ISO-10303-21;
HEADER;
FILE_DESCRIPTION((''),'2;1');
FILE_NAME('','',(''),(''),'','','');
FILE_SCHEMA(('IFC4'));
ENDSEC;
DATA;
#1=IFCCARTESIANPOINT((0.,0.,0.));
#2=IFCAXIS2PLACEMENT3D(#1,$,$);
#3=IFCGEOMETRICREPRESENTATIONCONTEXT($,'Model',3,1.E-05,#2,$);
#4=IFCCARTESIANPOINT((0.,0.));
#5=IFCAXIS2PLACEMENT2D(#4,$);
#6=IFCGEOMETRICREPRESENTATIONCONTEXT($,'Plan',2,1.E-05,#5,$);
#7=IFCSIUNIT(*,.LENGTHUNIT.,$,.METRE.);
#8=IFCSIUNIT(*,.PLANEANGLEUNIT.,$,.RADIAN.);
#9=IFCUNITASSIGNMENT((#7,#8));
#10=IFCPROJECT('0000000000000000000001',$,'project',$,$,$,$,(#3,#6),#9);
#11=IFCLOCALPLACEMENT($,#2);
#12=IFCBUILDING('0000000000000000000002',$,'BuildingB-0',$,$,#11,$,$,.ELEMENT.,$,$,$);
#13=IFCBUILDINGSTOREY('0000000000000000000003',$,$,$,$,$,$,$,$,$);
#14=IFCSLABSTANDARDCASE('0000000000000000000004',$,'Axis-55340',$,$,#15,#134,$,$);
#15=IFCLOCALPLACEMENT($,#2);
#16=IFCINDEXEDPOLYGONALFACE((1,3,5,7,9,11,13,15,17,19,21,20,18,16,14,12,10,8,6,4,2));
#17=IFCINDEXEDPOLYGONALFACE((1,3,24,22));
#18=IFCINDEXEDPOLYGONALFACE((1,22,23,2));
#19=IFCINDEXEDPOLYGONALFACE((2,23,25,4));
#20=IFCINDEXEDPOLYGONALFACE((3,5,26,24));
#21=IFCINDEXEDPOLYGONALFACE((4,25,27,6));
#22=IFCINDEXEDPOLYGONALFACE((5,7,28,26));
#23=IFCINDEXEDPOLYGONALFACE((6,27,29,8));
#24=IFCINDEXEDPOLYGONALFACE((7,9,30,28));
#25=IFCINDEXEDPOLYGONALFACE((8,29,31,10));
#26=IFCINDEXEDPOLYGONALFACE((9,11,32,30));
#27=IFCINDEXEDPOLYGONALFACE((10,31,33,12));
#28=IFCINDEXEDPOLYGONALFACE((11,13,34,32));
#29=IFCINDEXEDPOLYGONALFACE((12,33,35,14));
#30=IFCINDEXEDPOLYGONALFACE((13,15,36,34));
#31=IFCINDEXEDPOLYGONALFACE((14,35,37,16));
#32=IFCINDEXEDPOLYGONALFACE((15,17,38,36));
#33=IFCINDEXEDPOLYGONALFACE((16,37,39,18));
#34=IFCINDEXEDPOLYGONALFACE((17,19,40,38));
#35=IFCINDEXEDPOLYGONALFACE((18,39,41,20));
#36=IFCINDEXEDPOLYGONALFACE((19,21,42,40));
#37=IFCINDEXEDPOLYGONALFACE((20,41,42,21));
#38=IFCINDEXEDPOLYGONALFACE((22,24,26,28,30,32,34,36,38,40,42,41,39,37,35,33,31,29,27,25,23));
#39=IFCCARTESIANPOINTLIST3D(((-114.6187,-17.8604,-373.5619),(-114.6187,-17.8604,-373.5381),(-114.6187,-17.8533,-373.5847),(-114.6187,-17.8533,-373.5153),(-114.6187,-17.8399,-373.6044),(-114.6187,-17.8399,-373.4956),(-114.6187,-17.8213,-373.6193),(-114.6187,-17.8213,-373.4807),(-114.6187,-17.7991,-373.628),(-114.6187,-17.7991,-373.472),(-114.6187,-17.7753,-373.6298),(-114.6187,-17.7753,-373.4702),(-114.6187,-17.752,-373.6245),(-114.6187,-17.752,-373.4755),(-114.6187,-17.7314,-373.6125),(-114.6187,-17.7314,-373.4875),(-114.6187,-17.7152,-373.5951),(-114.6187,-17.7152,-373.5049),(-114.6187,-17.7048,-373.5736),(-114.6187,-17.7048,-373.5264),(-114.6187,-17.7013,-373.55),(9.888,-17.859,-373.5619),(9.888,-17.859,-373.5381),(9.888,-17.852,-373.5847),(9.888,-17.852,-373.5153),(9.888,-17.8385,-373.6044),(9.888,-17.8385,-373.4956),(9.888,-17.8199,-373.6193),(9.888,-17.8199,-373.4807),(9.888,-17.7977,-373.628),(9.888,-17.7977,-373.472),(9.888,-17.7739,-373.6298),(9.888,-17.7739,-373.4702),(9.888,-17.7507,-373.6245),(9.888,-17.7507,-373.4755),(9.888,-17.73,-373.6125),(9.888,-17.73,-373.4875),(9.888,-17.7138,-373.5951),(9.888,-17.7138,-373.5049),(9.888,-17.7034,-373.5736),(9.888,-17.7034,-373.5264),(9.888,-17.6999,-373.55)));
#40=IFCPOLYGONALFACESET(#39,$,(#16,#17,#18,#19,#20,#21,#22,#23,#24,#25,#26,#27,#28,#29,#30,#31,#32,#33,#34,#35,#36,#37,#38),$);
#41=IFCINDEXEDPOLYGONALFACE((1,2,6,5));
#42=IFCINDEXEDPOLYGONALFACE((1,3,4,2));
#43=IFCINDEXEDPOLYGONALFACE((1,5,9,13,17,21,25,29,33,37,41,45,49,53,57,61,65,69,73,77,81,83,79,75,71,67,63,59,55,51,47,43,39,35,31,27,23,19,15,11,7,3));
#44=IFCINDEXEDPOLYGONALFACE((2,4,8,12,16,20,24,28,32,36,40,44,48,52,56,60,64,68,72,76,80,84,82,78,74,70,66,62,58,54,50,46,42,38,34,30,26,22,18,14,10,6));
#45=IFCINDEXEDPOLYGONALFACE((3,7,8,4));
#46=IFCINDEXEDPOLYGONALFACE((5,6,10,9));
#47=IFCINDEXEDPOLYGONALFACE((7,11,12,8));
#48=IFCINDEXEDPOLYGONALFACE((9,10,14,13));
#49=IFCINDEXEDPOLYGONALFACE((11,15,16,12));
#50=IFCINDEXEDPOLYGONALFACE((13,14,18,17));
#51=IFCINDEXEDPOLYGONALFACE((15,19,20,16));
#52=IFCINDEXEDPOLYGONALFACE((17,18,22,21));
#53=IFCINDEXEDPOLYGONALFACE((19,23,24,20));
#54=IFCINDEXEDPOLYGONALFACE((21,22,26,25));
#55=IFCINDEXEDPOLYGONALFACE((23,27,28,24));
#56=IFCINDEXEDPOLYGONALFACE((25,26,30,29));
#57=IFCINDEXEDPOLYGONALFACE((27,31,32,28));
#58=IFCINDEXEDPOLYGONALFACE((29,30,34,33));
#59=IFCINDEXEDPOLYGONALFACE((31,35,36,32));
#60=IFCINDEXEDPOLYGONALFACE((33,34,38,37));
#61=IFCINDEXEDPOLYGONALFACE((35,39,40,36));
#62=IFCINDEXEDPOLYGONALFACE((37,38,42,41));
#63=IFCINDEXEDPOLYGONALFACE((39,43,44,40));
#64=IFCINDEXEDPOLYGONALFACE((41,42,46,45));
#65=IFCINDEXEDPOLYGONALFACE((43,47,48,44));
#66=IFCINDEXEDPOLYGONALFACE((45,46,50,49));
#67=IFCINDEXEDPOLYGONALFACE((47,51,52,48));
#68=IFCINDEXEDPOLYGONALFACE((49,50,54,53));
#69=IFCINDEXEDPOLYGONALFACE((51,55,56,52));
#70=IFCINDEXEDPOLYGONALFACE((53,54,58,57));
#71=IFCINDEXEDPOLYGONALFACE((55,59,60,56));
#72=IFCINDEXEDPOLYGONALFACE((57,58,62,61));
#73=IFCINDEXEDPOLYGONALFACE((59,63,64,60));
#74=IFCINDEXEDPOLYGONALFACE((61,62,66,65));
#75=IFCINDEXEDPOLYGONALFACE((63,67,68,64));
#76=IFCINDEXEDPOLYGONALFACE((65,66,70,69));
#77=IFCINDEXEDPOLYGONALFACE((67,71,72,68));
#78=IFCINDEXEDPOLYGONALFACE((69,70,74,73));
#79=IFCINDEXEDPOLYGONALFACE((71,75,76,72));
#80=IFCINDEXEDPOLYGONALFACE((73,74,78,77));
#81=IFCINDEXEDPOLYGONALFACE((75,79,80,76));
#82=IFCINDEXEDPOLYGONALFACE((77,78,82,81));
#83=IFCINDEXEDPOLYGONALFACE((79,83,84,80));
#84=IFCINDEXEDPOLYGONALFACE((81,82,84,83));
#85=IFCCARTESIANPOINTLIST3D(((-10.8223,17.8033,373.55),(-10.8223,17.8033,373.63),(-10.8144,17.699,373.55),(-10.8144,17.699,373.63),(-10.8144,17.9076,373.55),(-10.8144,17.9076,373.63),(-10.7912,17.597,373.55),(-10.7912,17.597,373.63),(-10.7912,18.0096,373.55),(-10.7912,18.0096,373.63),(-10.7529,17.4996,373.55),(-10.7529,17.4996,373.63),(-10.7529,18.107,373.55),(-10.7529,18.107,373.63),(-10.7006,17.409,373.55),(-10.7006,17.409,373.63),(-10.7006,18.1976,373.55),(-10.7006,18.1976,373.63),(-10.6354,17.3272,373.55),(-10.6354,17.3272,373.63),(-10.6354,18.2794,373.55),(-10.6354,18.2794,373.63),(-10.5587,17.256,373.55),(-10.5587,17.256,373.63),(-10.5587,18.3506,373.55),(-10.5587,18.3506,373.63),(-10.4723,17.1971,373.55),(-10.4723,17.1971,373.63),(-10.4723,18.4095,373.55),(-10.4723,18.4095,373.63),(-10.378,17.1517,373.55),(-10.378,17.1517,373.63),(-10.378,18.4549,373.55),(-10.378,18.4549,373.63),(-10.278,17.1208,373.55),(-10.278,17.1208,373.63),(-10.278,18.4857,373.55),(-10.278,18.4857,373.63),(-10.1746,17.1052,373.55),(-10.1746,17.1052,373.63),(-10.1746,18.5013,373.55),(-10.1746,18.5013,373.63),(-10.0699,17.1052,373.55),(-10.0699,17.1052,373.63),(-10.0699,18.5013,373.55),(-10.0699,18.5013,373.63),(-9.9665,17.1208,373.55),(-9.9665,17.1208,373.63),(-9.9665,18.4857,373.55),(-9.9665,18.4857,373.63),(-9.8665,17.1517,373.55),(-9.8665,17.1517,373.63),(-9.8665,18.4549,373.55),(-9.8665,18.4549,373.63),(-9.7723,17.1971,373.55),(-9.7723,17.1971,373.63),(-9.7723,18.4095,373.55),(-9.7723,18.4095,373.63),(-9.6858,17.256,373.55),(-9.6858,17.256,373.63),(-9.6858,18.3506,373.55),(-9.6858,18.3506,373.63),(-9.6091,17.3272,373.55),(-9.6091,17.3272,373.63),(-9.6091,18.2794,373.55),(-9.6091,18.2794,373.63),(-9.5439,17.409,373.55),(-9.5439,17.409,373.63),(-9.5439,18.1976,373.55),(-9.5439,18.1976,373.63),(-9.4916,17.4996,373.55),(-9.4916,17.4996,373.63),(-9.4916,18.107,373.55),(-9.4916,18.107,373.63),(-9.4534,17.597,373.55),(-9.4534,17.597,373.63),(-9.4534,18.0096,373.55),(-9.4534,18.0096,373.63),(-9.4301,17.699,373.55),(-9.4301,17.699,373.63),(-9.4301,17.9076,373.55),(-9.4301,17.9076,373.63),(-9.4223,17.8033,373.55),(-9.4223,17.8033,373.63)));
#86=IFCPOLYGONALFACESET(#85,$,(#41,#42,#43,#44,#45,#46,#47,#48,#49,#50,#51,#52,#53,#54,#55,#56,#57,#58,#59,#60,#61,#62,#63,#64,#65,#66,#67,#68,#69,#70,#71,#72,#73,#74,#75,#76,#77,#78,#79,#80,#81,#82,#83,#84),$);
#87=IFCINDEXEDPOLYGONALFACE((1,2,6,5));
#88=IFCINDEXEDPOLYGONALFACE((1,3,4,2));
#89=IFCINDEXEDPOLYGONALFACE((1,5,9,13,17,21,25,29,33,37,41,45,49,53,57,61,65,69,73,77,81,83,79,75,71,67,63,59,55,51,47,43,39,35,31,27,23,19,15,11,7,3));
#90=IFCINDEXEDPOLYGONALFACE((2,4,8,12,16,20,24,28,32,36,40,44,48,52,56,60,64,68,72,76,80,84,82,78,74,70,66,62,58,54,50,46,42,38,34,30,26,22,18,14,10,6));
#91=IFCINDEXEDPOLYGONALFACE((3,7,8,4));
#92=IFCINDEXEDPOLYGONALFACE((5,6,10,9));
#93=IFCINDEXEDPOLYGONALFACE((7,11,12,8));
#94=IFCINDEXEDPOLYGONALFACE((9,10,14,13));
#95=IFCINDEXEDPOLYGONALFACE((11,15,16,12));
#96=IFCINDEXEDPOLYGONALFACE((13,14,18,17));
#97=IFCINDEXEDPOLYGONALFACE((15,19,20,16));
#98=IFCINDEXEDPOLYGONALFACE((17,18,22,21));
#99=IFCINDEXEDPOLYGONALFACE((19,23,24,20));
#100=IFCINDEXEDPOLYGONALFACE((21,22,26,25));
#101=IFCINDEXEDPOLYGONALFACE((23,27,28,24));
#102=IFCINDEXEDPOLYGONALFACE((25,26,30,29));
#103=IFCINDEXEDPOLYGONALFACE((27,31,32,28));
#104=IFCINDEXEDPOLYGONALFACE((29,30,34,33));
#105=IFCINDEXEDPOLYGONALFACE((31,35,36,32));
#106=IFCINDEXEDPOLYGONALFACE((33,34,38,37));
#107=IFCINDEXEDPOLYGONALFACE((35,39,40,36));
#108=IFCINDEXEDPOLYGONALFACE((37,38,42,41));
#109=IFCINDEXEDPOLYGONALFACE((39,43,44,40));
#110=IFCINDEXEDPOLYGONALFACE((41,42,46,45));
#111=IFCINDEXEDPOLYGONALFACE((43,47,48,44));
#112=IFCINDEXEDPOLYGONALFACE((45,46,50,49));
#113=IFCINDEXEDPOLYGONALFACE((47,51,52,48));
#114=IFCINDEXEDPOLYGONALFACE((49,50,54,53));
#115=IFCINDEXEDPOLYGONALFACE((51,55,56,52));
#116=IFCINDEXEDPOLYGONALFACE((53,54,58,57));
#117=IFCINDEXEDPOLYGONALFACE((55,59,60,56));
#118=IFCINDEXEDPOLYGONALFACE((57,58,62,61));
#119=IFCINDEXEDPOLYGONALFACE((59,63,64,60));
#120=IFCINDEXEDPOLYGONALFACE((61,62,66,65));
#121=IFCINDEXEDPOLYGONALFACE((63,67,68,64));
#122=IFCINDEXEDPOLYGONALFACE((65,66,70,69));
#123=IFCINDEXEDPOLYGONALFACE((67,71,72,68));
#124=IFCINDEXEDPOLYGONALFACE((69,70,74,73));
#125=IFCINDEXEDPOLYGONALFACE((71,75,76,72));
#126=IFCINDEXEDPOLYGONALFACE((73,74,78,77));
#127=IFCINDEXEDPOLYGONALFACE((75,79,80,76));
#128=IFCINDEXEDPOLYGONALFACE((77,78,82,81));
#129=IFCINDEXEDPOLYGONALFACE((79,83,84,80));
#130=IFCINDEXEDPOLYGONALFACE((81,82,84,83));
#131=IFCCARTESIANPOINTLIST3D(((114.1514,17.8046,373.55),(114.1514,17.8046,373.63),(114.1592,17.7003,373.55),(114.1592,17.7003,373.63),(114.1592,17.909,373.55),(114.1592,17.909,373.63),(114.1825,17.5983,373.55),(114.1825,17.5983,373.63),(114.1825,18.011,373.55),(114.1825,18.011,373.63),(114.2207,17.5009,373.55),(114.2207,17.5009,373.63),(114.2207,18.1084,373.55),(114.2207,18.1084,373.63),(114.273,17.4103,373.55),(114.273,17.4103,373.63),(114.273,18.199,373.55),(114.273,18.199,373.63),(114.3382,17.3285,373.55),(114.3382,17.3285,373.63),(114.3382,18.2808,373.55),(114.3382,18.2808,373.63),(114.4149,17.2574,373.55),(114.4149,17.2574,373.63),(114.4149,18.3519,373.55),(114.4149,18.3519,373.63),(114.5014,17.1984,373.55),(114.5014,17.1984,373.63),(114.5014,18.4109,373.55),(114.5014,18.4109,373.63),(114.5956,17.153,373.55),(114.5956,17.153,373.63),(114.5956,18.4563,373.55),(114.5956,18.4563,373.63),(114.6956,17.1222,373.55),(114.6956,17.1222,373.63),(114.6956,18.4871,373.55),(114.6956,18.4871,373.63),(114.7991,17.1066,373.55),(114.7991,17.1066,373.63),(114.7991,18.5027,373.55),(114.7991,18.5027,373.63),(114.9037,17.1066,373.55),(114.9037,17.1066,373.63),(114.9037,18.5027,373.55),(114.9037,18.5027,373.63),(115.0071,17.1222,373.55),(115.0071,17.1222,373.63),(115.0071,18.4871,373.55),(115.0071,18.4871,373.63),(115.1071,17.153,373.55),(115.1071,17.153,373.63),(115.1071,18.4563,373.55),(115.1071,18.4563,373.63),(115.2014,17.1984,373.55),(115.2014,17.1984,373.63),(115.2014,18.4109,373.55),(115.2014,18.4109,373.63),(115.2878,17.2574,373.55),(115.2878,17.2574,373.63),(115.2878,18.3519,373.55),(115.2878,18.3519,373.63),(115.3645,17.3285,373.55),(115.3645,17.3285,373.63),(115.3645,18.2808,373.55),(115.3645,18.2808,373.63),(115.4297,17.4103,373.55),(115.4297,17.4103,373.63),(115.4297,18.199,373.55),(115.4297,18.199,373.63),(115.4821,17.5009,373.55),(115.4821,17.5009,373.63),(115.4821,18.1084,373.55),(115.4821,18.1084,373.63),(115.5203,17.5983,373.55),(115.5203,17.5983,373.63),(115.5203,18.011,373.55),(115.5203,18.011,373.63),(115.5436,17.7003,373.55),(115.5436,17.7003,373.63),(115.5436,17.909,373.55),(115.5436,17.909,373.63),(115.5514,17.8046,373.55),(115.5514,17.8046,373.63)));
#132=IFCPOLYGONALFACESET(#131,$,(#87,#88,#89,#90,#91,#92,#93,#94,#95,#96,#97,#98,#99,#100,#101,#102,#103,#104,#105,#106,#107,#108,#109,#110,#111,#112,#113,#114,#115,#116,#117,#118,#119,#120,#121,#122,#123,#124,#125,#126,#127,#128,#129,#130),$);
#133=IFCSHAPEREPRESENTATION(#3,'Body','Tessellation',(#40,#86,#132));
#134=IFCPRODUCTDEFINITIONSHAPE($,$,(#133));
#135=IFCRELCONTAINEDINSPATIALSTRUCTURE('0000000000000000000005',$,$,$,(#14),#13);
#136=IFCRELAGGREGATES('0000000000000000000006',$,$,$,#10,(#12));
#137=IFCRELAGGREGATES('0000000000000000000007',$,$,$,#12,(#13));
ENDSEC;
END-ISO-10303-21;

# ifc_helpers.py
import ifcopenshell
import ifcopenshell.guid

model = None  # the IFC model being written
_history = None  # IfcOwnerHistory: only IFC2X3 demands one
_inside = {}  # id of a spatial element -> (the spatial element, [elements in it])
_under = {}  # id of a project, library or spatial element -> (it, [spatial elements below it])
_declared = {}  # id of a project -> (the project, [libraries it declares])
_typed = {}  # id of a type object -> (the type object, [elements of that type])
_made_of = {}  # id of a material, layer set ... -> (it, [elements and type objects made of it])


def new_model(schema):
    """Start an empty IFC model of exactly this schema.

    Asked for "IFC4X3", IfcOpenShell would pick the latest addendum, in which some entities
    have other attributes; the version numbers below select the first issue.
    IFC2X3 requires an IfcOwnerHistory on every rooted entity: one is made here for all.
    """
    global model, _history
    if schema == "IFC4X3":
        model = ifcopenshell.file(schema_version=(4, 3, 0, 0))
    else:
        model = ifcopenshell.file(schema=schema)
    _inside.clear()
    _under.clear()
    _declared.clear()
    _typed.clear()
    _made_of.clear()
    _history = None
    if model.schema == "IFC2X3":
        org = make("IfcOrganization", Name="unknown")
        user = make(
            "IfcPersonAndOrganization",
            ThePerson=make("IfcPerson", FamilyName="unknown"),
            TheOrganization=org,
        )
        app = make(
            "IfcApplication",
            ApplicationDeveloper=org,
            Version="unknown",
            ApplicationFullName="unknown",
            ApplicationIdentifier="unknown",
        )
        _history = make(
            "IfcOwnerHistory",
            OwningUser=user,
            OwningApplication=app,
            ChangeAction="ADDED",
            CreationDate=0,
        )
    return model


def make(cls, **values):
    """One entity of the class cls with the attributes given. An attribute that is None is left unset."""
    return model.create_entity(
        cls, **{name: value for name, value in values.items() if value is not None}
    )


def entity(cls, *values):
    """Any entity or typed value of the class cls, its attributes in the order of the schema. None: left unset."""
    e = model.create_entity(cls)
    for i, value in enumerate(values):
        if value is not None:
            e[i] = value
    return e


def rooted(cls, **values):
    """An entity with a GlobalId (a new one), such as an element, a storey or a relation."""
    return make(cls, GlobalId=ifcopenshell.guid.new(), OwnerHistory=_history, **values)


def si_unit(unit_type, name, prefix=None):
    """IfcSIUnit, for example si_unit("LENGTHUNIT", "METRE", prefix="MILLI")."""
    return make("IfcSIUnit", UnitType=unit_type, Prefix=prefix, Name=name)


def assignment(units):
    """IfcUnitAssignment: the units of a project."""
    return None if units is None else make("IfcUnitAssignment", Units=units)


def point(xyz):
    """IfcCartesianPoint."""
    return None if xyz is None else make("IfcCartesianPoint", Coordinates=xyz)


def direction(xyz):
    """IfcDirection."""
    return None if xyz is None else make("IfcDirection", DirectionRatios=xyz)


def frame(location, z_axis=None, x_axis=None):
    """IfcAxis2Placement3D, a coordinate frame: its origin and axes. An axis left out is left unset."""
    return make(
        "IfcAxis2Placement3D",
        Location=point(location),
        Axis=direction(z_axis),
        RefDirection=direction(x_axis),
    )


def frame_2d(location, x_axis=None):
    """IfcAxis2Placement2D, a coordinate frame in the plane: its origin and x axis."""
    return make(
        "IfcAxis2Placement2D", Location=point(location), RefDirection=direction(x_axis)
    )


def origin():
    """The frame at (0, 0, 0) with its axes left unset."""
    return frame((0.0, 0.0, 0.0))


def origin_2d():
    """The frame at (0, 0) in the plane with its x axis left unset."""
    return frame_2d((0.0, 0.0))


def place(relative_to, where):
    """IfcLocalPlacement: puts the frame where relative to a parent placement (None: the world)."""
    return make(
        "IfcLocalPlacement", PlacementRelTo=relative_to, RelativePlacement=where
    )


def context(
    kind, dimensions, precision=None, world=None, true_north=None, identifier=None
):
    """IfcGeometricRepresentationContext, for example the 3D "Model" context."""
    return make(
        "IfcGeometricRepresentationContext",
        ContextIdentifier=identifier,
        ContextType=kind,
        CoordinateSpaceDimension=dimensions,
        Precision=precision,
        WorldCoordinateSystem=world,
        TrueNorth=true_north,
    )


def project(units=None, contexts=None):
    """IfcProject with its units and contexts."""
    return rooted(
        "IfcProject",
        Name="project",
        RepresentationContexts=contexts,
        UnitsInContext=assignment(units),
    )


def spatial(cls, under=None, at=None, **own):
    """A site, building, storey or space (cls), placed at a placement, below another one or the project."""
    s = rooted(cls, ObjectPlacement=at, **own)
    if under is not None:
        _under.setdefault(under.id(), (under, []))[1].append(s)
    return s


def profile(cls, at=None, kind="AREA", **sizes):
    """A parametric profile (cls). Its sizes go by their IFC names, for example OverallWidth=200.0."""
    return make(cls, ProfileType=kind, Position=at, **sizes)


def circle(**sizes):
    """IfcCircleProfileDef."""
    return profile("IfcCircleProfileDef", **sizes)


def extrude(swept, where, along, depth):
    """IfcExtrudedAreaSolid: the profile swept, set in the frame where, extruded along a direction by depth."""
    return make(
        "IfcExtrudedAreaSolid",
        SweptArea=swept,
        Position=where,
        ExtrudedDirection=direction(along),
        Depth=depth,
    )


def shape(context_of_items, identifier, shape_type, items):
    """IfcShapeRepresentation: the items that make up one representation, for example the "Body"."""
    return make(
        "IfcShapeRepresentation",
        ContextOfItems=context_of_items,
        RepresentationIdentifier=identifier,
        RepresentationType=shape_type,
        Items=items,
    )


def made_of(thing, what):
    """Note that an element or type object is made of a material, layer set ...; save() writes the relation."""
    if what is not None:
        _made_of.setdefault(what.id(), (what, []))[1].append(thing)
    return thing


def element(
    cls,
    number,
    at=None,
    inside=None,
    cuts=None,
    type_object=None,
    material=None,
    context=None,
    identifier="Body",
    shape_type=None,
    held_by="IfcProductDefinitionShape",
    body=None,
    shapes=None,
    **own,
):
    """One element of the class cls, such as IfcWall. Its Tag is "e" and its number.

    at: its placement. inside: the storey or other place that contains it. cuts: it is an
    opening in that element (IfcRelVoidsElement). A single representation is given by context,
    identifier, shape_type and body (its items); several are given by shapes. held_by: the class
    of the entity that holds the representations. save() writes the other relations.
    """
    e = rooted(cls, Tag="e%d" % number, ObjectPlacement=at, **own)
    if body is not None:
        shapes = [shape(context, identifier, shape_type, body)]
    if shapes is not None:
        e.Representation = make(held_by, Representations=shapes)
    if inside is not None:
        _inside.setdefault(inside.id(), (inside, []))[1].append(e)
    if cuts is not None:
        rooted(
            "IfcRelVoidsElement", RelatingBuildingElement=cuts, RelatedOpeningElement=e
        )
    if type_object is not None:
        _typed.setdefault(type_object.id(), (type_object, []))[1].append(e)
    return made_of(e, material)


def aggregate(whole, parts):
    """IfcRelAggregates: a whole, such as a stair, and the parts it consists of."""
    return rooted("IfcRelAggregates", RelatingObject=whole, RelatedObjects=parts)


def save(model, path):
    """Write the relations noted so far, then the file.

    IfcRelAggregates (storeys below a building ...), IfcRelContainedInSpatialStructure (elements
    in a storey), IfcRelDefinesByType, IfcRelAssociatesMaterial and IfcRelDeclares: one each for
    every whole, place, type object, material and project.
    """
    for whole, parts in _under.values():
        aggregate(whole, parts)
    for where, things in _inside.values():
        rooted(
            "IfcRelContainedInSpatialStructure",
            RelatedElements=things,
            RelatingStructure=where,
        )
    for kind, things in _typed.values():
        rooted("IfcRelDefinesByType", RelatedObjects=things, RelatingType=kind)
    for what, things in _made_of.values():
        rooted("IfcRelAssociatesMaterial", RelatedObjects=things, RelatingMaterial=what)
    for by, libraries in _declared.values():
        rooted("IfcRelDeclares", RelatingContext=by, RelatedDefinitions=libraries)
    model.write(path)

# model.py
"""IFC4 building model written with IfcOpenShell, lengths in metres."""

from ifc_helpers import new_model, entity, si_unit, frame, origin, origin_2d, place, context, project, spatial, circle, extrude, element, save


model = new_model("IFC4")

# Units and contexts
model_context = context("Model", 3, precision=1e-05, world=origin())
plan_context = context("Plan", 2, precision=1e-05, world=origin_2d())
ifc_project = project(units=[si_unit("LENGTHUNIT", "METRE"), si_unit("PLANEANGLEUNIT", "RADIAN")], contexts=[model_context, plan_context])

# Building, storey
building_placement = place(None, origin())
building = spatial("IfcBuilding", under=ifc_project, at=building_placement, Name="BuildingB-0", CompositionType="ELEMENT")
storey = spatial("IfcBuildingStorey", under=building)

# Slab
element("IfcSlabStandardCase", 1, inside=storey, Name="Axis-55340", context=model_context, shape_type="AdvancedSweptSolid", body=[
    entity("IfcSurfaceCurveSweptAreaSolid", entity("IfcCircleProfileDef", "AREA", None, None, 0.08), None, entity("IfcPolyline", [entity("IfcCartesianPoint", [-9.888, 17.7799, 373.55]), entity("IfcCartesianPoint", [114.6187, 17.7813, 373.55])]), None, None, entity("IfcPlane", entity("IfcAxis2Placement3D", entity("IfcCartesianPoint", [-9.888, 17.7799, 373.55]), entity("IfcDirection", [0.0, 0.0, 1.0]), entity("IfcDirection", [1.0, 0.0, 0.0])))),
    extrude(circle(Radius=0.7), frame((-10.1223, 17.8033, 373.55)), (0.0, 0.0, 1.0), 0.08),
    extrude(circle(Radius=0.7), frame((114.8514, 17.8046, 373.55)), (0.0, 0.0, 1.0), 0.08),
])

save(model, "model.ifc")
